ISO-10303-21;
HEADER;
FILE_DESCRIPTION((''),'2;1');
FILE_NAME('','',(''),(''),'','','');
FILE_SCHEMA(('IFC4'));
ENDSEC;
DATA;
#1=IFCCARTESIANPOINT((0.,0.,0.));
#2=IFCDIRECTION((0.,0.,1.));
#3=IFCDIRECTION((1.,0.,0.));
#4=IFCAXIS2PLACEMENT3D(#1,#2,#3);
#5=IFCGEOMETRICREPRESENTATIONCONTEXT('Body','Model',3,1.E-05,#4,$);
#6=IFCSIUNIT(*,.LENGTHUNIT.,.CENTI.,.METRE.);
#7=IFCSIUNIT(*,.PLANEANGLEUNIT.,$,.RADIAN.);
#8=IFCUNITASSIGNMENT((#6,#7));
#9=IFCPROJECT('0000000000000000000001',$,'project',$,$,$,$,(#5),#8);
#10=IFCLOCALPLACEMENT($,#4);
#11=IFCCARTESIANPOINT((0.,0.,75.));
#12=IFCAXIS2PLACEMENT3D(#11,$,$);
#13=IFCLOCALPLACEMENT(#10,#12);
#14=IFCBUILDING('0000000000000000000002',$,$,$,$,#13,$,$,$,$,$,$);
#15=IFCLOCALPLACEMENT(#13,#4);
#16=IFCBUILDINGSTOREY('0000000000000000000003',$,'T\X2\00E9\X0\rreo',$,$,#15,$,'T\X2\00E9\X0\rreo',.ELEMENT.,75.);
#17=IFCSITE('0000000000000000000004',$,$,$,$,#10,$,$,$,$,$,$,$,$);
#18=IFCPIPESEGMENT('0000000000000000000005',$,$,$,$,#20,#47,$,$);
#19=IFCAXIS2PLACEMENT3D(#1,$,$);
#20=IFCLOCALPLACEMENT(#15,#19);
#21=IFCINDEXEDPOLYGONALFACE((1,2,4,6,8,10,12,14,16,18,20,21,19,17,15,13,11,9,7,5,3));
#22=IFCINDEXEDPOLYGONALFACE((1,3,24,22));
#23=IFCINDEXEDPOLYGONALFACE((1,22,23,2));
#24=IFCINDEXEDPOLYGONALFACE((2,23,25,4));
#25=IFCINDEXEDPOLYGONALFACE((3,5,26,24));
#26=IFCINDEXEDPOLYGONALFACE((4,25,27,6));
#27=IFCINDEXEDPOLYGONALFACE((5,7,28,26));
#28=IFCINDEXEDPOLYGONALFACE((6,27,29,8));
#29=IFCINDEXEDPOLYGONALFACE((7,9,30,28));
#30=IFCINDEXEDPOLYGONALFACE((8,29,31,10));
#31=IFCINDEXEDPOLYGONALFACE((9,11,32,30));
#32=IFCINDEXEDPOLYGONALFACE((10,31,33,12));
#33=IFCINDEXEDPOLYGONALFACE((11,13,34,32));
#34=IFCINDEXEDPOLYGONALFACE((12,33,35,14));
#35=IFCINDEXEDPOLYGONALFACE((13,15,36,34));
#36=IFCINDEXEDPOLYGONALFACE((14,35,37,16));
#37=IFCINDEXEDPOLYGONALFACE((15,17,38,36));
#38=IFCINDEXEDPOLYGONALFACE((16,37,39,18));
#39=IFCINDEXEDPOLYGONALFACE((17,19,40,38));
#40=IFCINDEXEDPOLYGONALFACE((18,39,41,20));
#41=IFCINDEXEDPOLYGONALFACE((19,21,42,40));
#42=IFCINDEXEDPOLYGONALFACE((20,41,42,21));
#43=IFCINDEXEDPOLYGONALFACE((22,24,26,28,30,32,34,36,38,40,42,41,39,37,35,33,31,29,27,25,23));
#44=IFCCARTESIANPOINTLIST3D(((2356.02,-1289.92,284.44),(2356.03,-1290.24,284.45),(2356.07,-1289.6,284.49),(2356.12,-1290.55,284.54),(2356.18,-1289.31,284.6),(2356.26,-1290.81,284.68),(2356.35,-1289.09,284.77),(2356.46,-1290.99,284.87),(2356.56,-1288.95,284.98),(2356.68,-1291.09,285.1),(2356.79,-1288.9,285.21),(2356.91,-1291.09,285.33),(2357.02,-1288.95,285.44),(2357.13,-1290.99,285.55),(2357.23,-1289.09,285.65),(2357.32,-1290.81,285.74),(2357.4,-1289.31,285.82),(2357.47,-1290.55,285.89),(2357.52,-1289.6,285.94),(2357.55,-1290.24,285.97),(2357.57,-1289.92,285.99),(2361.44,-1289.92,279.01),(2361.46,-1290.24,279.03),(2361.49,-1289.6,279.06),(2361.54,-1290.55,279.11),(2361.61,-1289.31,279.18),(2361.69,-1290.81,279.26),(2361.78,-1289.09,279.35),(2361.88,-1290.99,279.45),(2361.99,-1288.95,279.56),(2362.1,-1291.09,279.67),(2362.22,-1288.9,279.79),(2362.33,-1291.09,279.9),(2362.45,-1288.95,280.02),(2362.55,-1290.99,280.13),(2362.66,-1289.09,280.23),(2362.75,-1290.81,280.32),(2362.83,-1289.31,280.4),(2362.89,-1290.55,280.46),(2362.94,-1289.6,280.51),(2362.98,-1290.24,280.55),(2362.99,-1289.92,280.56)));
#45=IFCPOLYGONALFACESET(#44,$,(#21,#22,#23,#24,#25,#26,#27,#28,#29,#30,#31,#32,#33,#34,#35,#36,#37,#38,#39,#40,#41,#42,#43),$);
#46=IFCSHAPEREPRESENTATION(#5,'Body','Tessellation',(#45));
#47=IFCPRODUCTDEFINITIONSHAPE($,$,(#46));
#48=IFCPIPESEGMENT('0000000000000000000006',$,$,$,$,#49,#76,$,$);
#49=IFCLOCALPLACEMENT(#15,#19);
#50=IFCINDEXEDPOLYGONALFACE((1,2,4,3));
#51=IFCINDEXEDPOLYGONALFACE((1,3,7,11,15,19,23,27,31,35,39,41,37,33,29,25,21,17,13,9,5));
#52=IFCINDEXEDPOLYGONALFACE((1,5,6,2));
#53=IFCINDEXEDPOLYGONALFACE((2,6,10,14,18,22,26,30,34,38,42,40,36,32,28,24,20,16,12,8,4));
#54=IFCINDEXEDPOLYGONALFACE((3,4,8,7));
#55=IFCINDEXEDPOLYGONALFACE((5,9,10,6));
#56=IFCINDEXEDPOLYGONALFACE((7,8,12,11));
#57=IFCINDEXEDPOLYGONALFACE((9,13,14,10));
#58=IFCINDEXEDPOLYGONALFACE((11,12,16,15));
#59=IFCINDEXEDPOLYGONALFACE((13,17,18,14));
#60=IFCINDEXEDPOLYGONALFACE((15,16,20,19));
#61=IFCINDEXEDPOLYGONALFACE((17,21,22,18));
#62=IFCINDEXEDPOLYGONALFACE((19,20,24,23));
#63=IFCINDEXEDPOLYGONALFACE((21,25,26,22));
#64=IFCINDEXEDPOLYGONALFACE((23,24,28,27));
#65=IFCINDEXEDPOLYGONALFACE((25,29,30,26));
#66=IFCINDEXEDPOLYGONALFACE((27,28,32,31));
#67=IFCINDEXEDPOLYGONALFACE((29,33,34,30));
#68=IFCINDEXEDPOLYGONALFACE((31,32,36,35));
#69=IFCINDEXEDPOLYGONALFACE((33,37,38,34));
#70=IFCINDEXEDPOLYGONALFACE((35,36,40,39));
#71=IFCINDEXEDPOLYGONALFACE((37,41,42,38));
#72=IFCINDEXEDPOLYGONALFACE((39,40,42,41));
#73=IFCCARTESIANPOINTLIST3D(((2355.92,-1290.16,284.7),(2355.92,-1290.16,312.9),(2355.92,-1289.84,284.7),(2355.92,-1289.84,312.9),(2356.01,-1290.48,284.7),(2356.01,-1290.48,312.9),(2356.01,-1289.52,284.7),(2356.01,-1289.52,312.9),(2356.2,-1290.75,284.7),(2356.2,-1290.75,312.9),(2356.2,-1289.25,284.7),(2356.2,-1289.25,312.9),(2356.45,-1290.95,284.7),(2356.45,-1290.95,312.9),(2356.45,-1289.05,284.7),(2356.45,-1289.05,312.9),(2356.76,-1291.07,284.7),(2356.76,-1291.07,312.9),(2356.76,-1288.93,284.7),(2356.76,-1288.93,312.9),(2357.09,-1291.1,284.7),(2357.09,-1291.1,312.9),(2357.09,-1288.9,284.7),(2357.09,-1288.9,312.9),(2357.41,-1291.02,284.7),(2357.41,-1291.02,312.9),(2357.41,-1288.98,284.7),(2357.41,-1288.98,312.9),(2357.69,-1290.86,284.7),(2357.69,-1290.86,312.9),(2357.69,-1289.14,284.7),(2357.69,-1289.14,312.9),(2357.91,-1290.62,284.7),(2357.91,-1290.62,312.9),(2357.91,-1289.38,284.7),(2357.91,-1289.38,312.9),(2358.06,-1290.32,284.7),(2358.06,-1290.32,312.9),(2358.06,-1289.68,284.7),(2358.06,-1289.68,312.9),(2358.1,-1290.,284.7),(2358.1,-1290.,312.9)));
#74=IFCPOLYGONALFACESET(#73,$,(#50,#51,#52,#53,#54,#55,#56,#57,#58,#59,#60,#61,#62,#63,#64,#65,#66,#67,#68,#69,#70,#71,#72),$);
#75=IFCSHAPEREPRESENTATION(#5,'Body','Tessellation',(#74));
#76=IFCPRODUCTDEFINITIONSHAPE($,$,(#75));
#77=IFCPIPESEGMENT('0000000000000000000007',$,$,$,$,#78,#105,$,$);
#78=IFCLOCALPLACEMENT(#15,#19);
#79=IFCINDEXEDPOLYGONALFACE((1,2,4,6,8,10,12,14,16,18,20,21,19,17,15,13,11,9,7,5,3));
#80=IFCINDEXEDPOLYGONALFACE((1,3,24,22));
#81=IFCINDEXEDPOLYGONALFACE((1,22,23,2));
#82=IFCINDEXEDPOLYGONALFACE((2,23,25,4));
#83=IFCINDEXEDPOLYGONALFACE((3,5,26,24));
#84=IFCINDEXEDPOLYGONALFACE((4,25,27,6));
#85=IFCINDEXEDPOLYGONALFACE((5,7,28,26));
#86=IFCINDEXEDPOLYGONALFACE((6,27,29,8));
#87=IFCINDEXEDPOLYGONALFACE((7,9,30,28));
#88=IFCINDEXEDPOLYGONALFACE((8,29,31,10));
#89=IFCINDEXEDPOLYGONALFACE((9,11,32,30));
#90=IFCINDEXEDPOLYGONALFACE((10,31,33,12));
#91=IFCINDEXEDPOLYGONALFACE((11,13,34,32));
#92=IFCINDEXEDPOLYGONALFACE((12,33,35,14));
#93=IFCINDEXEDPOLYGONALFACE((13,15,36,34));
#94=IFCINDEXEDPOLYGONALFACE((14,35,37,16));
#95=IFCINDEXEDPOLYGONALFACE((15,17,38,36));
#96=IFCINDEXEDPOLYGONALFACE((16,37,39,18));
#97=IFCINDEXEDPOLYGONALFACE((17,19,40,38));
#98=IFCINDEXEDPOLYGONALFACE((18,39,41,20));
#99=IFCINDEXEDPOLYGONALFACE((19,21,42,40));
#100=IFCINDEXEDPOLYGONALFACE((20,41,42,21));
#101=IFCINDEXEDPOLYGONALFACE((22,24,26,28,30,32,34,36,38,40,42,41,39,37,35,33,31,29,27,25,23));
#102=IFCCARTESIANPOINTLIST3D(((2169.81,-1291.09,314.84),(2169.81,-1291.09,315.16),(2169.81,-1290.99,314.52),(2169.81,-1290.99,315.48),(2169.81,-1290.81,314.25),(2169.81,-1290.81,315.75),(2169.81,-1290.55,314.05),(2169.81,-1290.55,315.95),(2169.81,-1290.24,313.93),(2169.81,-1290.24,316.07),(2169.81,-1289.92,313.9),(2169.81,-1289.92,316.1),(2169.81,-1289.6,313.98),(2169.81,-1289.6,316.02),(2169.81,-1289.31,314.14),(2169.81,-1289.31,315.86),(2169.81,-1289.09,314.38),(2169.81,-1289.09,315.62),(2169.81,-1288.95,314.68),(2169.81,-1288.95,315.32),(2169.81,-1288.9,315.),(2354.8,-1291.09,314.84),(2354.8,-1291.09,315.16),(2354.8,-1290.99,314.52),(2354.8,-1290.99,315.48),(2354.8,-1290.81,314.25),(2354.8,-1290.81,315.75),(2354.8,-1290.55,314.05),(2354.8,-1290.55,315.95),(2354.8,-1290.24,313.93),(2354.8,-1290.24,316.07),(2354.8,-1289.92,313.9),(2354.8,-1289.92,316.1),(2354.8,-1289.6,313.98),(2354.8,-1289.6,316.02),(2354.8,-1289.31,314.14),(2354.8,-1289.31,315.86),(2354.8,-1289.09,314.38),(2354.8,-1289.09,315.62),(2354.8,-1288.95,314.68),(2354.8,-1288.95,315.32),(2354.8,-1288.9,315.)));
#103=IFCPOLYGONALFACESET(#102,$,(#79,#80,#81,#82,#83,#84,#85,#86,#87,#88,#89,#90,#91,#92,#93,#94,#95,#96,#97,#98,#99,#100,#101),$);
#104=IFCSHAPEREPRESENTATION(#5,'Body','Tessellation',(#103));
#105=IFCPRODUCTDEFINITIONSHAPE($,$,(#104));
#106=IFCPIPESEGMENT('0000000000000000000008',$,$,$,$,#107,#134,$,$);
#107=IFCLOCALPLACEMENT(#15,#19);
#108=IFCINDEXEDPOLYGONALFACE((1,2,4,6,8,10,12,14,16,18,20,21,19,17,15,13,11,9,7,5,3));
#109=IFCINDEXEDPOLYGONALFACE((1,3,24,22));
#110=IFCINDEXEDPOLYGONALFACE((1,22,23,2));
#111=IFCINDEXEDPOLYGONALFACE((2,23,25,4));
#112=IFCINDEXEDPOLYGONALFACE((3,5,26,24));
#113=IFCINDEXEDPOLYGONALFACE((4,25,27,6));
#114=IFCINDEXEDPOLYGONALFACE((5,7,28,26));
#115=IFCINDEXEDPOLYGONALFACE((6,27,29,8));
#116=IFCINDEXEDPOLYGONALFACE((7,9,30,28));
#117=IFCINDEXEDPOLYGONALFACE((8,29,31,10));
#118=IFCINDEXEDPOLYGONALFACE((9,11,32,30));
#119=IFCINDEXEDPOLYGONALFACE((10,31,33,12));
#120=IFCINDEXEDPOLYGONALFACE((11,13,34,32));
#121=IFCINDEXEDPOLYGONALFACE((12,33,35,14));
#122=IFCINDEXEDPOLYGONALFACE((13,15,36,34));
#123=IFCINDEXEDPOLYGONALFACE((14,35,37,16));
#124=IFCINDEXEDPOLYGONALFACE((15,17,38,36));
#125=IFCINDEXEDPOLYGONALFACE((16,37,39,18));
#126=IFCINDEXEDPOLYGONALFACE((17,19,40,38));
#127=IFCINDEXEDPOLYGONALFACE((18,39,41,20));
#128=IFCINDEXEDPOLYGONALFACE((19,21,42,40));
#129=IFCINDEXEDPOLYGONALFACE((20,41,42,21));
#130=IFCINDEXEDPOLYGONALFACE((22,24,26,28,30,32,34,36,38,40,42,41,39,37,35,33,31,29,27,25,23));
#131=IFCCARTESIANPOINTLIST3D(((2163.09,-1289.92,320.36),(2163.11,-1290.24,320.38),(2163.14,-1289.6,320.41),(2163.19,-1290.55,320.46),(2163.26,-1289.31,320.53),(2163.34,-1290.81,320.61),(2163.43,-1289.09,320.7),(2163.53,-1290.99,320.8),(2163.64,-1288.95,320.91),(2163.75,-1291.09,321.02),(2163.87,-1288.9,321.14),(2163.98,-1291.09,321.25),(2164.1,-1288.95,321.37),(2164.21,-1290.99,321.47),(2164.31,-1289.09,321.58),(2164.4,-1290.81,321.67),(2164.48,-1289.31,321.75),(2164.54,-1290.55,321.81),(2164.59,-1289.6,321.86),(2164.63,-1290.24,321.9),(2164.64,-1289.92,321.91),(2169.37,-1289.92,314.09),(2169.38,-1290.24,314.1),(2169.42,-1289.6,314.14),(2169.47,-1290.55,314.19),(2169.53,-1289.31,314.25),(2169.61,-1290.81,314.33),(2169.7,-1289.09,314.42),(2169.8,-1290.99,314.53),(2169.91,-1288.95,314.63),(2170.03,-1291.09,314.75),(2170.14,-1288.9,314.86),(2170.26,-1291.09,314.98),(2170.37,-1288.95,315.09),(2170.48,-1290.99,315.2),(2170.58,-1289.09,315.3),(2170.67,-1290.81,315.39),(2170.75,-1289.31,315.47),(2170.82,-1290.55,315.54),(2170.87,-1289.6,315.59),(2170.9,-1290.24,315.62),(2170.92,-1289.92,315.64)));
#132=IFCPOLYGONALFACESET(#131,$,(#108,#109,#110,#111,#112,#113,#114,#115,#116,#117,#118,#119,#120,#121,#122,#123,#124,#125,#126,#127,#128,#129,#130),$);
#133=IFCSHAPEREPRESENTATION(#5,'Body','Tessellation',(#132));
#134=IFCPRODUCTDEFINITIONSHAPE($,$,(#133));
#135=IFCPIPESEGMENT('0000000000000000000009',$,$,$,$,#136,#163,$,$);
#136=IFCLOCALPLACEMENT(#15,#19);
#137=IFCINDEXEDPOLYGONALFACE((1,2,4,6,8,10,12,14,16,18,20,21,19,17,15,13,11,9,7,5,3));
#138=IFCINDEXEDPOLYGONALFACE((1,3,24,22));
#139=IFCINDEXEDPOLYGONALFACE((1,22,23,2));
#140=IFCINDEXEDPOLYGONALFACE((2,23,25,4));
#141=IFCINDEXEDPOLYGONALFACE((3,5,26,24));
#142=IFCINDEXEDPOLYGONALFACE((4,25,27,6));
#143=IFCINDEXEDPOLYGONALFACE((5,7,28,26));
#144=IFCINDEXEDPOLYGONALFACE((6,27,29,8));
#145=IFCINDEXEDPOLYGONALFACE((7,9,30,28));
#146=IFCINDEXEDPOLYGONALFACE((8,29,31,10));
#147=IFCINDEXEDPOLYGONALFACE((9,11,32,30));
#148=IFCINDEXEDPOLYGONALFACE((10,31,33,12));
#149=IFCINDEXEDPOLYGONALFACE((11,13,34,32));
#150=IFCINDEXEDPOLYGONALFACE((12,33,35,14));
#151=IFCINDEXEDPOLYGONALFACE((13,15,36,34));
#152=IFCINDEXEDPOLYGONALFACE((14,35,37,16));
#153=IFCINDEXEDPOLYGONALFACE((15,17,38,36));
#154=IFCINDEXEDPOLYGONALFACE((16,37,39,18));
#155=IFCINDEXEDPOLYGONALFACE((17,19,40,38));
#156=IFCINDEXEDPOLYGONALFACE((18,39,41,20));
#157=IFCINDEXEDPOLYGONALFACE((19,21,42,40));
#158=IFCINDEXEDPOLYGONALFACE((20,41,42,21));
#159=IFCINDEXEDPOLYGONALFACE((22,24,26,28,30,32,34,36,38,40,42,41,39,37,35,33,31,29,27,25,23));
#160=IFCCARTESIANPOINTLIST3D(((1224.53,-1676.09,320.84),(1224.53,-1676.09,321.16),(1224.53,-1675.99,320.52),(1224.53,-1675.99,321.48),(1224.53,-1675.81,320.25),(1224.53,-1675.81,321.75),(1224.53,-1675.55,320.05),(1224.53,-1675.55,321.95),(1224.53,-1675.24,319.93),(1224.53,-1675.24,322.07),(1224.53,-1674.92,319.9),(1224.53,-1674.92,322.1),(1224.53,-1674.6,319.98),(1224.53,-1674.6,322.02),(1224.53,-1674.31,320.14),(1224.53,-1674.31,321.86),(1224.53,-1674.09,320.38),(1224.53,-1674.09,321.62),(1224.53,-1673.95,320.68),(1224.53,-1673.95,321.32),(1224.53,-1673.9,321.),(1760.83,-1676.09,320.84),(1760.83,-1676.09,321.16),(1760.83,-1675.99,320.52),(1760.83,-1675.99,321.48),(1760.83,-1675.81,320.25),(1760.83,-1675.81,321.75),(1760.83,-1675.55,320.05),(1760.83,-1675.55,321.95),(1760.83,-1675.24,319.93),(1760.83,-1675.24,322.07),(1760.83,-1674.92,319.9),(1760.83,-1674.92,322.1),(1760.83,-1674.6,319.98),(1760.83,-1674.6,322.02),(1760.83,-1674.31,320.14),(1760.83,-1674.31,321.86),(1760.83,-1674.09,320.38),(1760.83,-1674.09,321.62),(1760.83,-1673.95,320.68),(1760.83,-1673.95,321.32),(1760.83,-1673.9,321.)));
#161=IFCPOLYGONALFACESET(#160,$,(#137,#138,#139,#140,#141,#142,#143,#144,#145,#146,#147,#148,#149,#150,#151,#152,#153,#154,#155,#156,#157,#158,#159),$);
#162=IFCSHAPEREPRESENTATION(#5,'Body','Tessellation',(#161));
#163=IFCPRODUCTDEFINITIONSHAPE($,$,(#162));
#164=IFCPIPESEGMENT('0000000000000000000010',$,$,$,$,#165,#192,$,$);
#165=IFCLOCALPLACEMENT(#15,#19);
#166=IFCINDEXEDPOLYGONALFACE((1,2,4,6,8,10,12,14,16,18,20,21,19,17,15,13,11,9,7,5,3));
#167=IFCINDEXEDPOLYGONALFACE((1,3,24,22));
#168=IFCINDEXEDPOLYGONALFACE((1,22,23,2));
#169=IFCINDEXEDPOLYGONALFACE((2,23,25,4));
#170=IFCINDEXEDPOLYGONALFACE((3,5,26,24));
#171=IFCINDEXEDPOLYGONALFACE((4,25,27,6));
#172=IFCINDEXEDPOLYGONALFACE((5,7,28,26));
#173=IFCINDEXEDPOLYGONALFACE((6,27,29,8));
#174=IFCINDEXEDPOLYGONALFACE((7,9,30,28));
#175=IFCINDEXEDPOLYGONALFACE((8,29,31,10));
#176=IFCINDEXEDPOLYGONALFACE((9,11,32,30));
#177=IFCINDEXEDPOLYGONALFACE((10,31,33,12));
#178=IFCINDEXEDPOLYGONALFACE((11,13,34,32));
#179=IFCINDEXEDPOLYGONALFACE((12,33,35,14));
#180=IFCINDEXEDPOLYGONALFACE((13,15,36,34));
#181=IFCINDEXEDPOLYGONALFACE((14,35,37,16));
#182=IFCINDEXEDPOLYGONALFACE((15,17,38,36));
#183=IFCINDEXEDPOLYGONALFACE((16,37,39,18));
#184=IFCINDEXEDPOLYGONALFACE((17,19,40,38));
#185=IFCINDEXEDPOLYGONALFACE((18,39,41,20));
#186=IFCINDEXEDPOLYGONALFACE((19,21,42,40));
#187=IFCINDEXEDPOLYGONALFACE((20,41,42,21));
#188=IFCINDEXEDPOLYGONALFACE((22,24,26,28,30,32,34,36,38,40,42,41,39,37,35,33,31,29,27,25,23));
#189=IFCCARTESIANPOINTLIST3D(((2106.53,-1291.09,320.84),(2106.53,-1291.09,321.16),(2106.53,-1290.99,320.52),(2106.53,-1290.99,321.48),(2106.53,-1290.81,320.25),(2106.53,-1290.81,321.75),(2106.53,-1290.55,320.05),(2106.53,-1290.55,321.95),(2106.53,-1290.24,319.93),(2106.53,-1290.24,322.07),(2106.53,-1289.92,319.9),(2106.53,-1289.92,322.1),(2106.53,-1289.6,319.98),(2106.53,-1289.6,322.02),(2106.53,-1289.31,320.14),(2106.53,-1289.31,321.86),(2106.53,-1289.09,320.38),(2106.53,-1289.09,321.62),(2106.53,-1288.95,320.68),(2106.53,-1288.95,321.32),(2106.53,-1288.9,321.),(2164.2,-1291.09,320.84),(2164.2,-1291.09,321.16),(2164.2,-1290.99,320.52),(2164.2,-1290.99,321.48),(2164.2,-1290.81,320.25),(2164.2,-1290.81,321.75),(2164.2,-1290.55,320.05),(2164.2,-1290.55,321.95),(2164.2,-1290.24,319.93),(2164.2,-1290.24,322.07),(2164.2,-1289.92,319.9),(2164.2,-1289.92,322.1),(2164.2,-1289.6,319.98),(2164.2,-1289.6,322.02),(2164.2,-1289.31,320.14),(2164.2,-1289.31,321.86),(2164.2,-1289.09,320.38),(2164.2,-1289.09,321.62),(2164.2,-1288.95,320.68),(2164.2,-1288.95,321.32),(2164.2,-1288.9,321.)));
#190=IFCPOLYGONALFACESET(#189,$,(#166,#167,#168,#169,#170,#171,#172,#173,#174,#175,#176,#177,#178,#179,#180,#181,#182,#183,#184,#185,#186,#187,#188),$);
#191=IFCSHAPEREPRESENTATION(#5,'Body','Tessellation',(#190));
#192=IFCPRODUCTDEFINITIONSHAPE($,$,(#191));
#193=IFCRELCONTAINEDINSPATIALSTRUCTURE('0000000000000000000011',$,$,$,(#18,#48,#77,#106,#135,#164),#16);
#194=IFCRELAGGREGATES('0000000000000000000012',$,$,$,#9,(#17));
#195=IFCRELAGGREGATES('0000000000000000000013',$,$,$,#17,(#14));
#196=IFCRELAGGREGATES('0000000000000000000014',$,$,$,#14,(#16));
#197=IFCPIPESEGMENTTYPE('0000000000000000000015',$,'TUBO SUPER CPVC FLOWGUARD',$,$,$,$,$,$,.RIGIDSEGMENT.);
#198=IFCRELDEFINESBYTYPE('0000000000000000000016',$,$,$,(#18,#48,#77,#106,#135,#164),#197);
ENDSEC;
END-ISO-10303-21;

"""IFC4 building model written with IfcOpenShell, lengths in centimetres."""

from ifc_helpers import new_model, si_unit, frame, origin_with_axes, origin_2d_with_axis, place, context, project, spatial, circle, extrude, type_object, element, save


model = new_model("IFC4")

# Units and contexts
model_context = context("Model", 3, precision=1e-05, world=origin_with_axes(), identifier="Body")
ifc_project = project(units=[si_unit("LENGTHUNIT", "METRE", prefix="CENTI"), si_unit("PLANEANGLEUNIT", "RADIAN")], contexts=[model_context])

# Site, building, storey
site_placement = place(None, origin_with_axes())
site = spatial("IfcSite", under=ifc_project, at=site_placement)
building_placement = place(site_placement, frame((0.0, 0.0, 75.0)))
building = spatial("IfcBuilding", under=site, at=building_placement)
storey_placement = place(building_placement, origin_with_axes())
storey = spatial("IfcBuildingStorey", under=building, at=storey_placement, Name="Térreo", LongName="Térreo", CompositionType="ELEMENT", Elevation=75.0)

# Pipe segments
pipe_segment_type_1 = type_object("IfcPipeSegmentType", Name="TUBO SUPER CPVC FLOWGUARD", PredefinedType="RIGIDSEGMENT")
pipe_segment_1_placement = place(storey_placement, frame((2359.5, -1290.0, 285.99), z_axis=(0.0, 0.0, 1.0), x_axis=(1.0, 0.0, 0.0)))
element("IfcPipeSegment", 1, at=pipe_segment_1_placement, inside=storey, type_object=pipe_segment_type_1, context=model_context, shape_type="SolidModel", body=[
    extrude(circle(Radius=1.1, at=origin_2d_with_axis()), frame((-2.71, 0.0, -0.78), z_axis=(0.707107, 0.0, -0.707107), x_axis=(0.0, 1.0, 0.0)), (0.0, 0.0, 1.0), 7.67),
])
pipe_segment_2_placement = place(storey_placement, frame((2357.0, -1290.0, 312.9), z_axis=(0.0, 0.0, 1.0), x_axis=(1.0, 0.0, 0.0)))
element("IfcPipeSegment", 2, at=pipe_segment_2_placement, inside=storey, type_object=pipe_segment_type_1, context=model_context, shape_type="SolidModel", body=[
    extrude(circle(Radius=1.1, at=origin_2d_with_axis()), frame((0.0, 0.0, 0.0), z_axis=(0.0, 0.0, -1.0), x_axis=(1.0, 0.0, 0.0)), (0.0, 0.0, 1.0), 28.2),
])
pipe_segment_3_placement = place(storey_placement, frame((2262.31, -1290.0, 316.1), z_axis=(0.0, 0.0, 1.0), x_axis=(1.0, 0.0, 0.0)))
element("IfcPipeSegment", 3, at=pipe_segment_3_placement, inside=storey, type_object=pipe_segment_type_1, context=model_context, shape_type="SolidModel", body=[
    extrude(circle(Radius=1.1, at=origin_2d_with_axis()), frame((-92.5, 0.0, -1.1), z_axis=(1.0, 0.0, 0.0), x_axis=(0.0, 1.0, 0.0)), (0.0, 0.0, 1.0), 184.99),
])
pipe_segment_4_placement = place(storey_placement, frame((2167.0, -1290.0, 321.92), z_axis=(0.0, 0.0, 1.0), x_axis=(1.0, 0.0, 0.0)))
element("IfcPipeSegment", 4, at=pipe_segment_4_placement, inside=storey, type_object=pipe_segment_type_1, context=model_context, shape_type="SolidModel", body=[
    extrude(circle(Radius=1.1, at=origin_2d_with_axis()), frame((-3.14, 0.0, -0.78), z_axis=(0.707107, 0.0, -0.707107), x_axis=(0.0, 1.0, 0.0)), (0.0, 0.0, 1.0), 8.87),
])
pipe_segment_5_placement = place(storey_placement, frame((1492.68, -1675.0, 322.1), z_axis=(0.0, 0.0, 1.0), x_axis=(1.0, 0.0, 0.0)))
element("IfcPipeSegment", 5, at=pipe_segment_5_placement, inside=storey, type_object=pipe_segment_type_1, context=model_context, shape_type="SolidModel", body=[
    extrude(circle(Radius=1.1, at=origin_2d_with_axis()), frame((268.15, 0.0, -1.1), z_axis=(-1.0, 0.0, 0.0), x_axis=(0.0, 1.0, 0.0)), (0.0, 0.0, 1.0), 536.29),
])
pipe_segment_6_placement = place(storey_placement, frame((2135.37, -1290.0, 322.1), z_axis=(0.0, 0.0, 1.0), x_axis=(1.0, 0.0, 0.0)))
element("IfcPipeSegment", 6, at=pipe_segment_6_placement, inside=storey, type_object=pipe_segment_type_1, context=model_context, shape_type="SolidModel", body=[
    extrude(circle(Radius=1.1, at=origin_2d_with_axis()), frame((-28.83, 0.0, -1.1), z_axis=(1.0, 0.0, 0.0), x_axis=(0.0, 1.0, 0.0)), (0.0, 0.0, 1.0), 57.66),
])

save(model, "model.ifc")
